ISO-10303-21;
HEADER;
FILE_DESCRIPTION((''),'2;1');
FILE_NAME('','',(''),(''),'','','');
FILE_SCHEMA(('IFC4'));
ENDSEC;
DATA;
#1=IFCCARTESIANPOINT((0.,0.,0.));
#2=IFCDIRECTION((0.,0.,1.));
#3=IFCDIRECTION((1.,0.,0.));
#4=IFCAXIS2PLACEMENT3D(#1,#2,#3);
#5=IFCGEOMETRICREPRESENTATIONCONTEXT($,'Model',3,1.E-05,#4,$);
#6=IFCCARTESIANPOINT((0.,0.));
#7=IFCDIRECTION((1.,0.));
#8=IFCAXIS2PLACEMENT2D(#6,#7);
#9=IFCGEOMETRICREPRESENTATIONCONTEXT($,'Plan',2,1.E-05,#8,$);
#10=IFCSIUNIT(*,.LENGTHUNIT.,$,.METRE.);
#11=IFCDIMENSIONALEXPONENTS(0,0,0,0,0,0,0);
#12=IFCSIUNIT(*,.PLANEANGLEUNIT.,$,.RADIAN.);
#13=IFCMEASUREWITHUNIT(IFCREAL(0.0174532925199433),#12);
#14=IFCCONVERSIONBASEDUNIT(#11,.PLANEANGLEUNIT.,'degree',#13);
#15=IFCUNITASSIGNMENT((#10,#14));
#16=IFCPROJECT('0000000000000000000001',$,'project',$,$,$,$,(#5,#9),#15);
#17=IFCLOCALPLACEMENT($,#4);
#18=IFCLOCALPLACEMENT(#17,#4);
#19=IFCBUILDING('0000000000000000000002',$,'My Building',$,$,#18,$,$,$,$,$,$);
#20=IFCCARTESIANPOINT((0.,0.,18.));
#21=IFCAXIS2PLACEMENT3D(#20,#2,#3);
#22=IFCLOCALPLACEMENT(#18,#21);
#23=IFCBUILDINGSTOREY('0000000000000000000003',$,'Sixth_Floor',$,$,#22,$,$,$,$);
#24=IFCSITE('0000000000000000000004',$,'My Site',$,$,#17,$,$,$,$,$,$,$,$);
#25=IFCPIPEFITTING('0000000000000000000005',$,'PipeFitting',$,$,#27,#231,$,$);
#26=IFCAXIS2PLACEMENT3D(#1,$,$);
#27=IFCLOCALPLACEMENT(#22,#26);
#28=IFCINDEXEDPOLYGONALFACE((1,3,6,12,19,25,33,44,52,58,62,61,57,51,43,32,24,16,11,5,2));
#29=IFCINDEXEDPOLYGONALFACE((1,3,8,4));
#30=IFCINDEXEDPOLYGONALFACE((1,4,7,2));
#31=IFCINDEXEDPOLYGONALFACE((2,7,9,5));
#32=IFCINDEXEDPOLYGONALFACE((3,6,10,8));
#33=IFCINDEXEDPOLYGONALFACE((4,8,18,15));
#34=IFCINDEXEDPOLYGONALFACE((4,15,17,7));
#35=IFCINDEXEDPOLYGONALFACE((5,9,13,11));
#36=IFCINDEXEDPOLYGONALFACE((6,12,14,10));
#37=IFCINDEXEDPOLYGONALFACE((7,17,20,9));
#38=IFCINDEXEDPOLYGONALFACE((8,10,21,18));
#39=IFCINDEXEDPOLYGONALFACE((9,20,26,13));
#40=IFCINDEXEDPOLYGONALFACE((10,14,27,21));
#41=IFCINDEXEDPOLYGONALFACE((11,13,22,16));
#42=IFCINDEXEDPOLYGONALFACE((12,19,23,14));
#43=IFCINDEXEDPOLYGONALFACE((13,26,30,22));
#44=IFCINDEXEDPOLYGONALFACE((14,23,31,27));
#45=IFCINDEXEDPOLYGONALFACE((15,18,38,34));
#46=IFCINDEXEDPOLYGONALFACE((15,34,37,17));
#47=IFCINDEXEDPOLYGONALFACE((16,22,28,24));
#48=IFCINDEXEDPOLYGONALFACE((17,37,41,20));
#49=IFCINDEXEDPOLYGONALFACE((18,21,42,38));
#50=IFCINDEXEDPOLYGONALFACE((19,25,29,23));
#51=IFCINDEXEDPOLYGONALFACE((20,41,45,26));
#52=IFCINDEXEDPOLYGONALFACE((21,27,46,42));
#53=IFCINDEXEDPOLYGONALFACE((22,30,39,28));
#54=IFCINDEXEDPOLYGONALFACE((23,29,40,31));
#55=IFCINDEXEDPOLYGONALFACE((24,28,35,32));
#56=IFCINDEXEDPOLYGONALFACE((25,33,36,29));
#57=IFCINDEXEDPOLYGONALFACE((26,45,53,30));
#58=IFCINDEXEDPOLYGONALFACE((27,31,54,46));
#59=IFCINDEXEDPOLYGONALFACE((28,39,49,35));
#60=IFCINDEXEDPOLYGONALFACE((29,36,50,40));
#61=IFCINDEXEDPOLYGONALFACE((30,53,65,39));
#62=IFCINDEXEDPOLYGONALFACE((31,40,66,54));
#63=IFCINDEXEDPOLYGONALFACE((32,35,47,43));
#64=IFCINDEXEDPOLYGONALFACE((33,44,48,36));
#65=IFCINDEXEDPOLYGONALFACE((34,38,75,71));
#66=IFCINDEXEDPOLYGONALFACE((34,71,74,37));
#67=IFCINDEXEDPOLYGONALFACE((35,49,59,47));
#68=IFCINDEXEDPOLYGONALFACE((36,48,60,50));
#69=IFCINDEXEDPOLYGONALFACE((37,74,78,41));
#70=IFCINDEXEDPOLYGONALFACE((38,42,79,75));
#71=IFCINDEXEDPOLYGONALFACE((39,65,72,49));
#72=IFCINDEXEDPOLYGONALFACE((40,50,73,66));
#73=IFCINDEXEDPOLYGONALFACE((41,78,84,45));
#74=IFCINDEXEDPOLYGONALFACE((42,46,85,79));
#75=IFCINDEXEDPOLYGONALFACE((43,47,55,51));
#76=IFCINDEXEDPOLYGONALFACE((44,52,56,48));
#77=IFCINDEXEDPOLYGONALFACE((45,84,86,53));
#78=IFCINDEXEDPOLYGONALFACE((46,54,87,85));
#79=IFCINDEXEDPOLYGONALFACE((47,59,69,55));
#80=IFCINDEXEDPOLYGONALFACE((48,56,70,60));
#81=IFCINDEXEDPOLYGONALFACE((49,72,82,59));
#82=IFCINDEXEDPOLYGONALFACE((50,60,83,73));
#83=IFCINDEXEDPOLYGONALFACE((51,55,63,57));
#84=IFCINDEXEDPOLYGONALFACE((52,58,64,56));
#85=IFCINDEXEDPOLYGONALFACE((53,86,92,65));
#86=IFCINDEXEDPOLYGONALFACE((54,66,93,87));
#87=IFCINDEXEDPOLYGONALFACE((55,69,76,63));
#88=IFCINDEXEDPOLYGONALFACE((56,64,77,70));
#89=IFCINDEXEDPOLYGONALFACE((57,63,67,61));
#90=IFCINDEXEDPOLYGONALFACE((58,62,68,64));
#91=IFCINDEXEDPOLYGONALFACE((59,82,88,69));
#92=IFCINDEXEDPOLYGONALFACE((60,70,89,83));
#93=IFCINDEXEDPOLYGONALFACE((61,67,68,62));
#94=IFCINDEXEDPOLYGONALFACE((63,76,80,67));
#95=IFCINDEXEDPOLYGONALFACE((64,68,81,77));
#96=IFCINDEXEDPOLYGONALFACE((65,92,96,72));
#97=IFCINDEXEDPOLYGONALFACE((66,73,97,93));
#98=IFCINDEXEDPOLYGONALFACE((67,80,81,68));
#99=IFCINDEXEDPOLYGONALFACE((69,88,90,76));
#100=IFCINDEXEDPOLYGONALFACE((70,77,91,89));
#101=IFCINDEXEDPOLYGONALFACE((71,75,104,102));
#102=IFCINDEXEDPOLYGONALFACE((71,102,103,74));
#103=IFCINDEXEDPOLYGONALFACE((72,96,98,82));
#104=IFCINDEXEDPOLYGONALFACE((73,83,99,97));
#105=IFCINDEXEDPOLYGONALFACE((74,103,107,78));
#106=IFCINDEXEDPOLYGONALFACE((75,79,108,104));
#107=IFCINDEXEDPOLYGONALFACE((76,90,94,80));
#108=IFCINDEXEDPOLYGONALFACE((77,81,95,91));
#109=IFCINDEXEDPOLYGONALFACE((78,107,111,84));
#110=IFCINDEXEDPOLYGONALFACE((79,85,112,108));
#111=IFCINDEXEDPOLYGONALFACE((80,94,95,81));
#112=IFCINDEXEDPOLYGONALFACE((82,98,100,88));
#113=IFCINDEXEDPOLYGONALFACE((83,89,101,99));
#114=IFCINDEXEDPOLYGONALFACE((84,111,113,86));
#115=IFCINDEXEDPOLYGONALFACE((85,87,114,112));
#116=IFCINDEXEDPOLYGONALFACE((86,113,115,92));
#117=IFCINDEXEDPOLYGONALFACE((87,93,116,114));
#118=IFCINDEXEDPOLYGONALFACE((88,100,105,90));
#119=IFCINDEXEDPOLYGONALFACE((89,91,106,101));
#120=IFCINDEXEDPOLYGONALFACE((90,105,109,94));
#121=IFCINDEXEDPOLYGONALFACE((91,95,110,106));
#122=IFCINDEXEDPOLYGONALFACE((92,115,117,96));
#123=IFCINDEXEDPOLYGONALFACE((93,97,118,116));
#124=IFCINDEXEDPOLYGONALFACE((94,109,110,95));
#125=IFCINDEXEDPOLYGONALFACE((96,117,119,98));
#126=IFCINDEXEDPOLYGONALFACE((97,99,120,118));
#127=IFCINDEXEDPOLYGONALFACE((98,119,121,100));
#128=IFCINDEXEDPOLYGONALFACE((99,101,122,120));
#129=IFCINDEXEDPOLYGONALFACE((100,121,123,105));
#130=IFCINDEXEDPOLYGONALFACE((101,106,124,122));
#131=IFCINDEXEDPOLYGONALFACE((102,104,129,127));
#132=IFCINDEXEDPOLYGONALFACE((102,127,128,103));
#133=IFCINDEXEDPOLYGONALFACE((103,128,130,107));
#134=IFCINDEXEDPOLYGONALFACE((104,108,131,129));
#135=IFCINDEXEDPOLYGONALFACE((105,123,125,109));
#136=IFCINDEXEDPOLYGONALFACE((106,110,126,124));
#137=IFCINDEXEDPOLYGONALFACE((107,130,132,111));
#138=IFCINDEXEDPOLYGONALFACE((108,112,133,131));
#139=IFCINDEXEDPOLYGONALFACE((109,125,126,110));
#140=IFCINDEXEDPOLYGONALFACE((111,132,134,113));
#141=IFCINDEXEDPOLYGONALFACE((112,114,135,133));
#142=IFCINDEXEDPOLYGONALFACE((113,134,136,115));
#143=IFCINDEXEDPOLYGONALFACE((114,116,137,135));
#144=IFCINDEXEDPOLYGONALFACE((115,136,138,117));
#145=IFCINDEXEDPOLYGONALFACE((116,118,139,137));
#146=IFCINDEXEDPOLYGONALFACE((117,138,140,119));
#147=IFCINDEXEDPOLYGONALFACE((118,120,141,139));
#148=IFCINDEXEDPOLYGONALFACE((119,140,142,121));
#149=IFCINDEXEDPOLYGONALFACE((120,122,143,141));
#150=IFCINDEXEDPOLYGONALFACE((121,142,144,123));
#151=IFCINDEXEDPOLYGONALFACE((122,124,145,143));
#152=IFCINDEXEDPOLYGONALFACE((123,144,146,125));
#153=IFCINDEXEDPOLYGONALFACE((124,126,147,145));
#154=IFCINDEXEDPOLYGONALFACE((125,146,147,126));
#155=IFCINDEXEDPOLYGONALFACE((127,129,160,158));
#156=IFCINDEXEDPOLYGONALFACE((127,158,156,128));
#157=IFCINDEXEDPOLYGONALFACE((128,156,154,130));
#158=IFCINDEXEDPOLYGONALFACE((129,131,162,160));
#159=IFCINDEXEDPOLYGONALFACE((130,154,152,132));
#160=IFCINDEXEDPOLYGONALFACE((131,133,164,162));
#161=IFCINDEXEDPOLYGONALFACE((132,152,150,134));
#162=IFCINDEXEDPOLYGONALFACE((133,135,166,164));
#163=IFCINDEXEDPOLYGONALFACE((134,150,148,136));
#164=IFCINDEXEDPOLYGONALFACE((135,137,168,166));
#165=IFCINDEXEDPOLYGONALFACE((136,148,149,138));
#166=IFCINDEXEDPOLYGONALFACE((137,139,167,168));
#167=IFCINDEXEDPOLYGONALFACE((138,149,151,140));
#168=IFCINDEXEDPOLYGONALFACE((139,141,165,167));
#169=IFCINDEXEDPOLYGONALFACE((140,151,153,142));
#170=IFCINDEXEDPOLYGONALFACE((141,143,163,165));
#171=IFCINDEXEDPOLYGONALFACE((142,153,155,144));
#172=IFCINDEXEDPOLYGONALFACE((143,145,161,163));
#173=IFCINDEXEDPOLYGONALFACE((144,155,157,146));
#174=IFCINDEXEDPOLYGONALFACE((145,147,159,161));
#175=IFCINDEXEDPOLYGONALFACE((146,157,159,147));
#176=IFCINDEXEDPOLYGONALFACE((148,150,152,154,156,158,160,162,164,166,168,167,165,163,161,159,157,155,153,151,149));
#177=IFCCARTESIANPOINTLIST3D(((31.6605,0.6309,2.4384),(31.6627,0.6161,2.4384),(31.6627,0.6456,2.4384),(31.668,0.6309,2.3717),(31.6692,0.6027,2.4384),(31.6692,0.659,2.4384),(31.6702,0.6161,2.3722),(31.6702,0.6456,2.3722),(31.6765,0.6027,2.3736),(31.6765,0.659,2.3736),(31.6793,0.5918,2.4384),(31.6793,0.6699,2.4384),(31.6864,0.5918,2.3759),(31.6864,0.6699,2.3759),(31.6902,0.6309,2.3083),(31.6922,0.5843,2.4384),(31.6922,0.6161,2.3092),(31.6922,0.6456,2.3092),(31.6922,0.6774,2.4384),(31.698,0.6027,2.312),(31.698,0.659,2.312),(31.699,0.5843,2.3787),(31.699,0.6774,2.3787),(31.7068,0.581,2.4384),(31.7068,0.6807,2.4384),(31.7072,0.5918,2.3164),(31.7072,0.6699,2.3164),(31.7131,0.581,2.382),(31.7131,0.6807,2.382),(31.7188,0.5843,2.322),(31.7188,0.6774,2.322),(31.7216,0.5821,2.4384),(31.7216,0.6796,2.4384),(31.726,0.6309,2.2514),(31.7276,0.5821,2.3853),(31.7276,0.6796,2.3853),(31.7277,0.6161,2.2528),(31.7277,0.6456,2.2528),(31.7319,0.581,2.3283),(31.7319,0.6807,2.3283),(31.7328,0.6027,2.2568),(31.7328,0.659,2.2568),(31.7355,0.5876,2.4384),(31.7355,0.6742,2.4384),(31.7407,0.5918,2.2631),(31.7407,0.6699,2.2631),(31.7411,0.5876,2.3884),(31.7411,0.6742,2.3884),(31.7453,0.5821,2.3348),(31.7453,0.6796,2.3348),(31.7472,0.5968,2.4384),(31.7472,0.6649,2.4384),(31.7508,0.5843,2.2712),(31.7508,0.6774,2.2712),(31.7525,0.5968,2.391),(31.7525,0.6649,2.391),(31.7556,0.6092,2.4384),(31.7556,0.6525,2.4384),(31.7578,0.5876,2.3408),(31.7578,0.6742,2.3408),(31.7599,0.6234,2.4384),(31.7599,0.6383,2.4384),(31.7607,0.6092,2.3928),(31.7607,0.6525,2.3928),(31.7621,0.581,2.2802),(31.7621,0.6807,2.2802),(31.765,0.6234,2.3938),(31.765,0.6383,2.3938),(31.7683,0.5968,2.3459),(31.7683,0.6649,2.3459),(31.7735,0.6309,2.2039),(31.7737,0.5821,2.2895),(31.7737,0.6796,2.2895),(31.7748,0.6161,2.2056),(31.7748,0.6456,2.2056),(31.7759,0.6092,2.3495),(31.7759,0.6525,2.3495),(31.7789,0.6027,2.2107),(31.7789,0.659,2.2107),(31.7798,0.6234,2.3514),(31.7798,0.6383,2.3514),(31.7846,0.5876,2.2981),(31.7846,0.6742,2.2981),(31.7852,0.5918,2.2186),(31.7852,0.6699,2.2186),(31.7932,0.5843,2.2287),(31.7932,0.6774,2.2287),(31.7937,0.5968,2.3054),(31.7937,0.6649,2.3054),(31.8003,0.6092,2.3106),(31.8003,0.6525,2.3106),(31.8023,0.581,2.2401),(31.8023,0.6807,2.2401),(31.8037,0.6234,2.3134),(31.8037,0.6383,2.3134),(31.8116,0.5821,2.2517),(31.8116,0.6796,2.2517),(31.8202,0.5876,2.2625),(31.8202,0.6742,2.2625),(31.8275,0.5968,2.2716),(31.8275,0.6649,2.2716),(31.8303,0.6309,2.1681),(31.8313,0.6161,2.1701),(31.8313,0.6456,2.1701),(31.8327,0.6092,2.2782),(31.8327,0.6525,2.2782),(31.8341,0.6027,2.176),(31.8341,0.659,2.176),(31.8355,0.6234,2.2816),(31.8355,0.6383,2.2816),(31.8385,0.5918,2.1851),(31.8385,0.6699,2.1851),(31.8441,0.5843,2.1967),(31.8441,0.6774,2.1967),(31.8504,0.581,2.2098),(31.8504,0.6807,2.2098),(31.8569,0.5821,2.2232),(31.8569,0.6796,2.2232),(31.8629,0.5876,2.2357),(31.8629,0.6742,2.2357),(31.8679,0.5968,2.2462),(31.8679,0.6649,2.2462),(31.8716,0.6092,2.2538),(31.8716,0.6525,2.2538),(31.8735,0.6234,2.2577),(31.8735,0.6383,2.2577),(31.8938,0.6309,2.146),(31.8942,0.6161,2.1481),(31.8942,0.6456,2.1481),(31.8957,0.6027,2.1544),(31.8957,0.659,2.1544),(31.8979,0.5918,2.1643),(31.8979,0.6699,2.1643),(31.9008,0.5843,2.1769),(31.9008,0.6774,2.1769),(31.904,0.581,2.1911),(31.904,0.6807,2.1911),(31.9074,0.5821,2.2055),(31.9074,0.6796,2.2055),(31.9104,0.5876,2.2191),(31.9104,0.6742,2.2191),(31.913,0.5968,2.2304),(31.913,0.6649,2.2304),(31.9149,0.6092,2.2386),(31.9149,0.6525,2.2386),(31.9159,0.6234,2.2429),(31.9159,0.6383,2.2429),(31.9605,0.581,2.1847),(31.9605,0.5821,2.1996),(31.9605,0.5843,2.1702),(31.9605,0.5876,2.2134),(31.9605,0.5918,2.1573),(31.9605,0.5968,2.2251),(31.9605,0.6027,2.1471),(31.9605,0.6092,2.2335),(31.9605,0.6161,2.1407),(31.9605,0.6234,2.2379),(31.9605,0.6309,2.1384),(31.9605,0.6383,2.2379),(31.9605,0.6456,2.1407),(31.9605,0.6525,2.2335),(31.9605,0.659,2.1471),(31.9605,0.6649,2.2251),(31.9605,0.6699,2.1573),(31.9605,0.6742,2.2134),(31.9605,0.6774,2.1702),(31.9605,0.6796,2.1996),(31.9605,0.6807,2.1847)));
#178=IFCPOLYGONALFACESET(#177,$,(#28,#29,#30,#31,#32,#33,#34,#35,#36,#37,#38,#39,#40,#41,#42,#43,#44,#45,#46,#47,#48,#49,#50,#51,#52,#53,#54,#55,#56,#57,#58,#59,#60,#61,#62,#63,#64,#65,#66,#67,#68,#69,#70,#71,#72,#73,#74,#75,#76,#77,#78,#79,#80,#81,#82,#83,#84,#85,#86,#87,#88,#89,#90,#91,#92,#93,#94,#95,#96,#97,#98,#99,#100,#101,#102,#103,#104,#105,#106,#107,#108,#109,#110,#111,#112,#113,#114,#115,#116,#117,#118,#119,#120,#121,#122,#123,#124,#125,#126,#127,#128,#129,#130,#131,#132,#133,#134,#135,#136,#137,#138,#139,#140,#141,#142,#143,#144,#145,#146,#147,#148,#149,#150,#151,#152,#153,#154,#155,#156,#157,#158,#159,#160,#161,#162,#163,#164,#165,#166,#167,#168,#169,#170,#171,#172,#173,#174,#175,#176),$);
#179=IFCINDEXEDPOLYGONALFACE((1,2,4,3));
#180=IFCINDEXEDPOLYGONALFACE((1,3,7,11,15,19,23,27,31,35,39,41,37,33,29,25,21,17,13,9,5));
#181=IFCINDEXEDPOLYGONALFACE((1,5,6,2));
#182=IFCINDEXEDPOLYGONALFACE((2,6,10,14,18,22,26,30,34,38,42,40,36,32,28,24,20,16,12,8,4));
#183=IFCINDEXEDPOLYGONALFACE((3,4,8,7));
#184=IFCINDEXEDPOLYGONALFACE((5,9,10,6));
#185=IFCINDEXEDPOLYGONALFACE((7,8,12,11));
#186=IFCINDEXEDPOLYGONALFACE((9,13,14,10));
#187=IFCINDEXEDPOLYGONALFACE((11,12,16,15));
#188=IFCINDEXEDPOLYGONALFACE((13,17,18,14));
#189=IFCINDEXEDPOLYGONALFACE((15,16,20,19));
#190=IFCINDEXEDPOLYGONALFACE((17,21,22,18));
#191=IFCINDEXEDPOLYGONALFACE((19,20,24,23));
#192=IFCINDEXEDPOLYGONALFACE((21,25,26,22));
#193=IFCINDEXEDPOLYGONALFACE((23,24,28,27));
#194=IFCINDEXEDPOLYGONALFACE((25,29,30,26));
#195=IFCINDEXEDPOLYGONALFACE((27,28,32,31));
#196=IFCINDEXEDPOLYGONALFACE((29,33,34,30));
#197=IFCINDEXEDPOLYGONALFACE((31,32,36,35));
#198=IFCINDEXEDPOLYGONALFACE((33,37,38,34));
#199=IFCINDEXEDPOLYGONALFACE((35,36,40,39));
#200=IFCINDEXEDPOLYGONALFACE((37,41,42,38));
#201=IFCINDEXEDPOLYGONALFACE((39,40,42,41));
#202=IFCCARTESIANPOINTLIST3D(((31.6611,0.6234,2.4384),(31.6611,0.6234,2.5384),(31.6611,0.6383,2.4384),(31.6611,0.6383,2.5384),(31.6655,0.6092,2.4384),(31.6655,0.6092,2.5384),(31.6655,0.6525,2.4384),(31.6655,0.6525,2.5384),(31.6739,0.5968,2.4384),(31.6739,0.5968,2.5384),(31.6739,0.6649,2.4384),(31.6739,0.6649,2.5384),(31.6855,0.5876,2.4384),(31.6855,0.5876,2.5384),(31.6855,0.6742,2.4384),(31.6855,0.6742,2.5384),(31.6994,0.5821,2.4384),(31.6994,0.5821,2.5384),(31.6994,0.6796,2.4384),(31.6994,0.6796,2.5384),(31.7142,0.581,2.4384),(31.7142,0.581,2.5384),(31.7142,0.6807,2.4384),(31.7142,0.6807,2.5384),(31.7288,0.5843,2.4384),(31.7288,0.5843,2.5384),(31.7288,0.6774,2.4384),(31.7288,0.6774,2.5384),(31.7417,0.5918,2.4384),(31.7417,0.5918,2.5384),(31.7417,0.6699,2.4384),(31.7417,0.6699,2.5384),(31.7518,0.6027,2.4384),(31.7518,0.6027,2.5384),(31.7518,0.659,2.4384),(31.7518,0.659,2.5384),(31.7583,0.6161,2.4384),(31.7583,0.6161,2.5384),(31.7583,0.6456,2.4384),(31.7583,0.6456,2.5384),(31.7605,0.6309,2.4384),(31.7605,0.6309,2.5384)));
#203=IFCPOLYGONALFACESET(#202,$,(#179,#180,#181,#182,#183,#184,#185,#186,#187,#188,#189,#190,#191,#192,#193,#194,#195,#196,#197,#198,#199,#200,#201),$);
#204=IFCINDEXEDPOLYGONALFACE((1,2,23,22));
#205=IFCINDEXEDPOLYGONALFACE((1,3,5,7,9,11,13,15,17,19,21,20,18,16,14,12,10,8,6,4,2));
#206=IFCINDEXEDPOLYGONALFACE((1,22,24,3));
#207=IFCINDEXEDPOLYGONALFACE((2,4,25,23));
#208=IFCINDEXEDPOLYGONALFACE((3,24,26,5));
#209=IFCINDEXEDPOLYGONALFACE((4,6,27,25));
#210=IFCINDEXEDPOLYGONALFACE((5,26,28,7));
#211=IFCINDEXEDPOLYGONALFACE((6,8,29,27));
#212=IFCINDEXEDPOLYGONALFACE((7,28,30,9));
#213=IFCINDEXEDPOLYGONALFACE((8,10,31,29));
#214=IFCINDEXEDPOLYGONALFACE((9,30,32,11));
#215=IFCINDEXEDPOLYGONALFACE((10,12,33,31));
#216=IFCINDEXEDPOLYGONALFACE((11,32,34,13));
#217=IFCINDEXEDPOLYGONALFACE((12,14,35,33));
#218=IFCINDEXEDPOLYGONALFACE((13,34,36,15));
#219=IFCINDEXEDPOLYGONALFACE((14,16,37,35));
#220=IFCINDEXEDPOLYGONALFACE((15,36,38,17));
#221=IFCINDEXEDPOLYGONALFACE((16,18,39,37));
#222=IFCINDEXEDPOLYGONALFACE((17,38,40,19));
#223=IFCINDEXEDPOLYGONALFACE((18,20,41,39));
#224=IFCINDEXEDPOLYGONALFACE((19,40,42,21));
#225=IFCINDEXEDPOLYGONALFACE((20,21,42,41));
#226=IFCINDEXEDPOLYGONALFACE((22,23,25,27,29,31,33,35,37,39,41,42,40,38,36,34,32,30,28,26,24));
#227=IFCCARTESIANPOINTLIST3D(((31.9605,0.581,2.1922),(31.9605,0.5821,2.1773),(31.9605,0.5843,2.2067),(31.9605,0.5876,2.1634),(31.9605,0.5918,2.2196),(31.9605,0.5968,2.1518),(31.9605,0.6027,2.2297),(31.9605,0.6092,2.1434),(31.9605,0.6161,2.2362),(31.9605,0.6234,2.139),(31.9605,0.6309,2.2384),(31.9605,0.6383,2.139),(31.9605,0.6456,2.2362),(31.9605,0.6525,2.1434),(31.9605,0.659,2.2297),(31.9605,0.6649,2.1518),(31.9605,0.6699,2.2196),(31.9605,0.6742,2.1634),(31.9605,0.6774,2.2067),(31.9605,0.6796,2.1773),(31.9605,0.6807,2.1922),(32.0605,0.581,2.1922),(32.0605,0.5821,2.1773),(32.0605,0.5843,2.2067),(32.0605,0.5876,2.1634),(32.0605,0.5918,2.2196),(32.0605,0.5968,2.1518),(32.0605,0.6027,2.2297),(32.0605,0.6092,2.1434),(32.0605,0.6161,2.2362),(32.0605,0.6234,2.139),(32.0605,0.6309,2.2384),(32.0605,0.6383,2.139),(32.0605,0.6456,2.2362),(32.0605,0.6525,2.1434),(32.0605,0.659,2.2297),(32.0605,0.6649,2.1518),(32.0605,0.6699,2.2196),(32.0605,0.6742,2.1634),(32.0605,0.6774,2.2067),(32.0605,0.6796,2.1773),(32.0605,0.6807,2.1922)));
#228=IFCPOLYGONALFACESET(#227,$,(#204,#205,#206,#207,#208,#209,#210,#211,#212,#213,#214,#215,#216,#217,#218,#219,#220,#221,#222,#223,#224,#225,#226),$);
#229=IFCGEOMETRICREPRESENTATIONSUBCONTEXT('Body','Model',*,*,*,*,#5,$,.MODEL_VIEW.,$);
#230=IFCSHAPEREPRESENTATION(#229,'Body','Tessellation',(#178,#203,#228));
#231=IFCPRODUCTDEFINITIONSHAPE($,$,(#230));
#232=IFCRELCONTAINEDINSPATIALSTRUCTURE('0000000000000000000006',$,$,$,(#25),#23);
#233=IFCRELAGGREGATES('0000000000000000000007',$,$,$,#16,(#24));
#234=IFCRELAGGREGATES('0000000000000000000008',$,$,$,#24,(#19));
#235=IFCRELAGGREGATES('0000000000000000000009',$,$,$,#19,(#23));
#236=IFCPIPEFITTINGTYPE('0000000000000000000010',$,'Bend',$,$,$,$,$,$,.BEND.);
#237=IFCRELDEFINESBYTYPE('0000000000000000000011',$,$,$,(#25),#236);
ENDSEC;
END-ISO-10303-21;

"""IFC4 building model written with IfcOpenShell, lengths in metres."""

from ifc_helpers import new_model, entity, si_unit, converted_unit, frame, origin_with_axes, origin_2d_with_axis, place, context, subcontext, project, spatial, circle, extrude, source, transform, mapped, type_object, type_shapes, element, save


model = new_model("IFC4")

# Units and contexts
model_context = context("Model", 3, precision=1e-05, world=origin_with_axes())
plan_context = context("Plan", 2, precision=1e-05, world=origin_2d_with_axis())
body_context = subcontext(model_context, "Body", "Model", "MODEL_VIEW")
ifc_project = project(units=[si_unit("LENGTHUNIT", "METRE"), converted_unit("PLANEANGLEUNIT", "degree", entity("IfcReal", 0.0174532925199433), si_unit("PLANEANGLEUNIT", "RADIAN"), dimensions=[0, 0, 0, 0, 0, 0, 0])], contexts=[model_context, plan_context])

# Site, building, storey
site_placement = place(None, origin_with_axes())
site = spatial("IfcSite", under=ifc_project, at=site_placement, Name="My Site")
building_placement = place(site_placement, origin_with_axes())
building = spatial("IfcBuilding", under=site, at=building_placement, Name="My Building")
storey_placement = place(building_placement, frame((0.0, 0.0, 18.0), z_axis=(0.0, 0.0, 1.0), x_axis=(1.0, 0.0, 0.0)))
storey = spatial("IfcBuildingStorey", under=building, at=storey_placement, Name="Sixth_Floor")

# Pipe fitting
pipe_fitting_type = type_object("IfcPipeFittingType", Name="Bend", PredefinedType="BEND")
shared_shape = source(origin_with_axes(), body_context, "Body", "SolidModel", [
    entity("IfcSweptDiskSolid", entity("IfcIndexedPolyCurve", entity("IfcCartesianPointList3D", [[0.0, 0.0, -0.1], [0.0732, 0.0, -0.2768], [0.25, 0.0, -0.35]]), [entity("IfcArcIndex", [1, 2, 3])]), 0.05),
    extrude(circle(Radius=0.05), origin_with_axes(), (0.0, 0.0, -1.0), 0.1),
    extrude(circle(Radius=0.05), frame((0.25, 0.0, -0.35), z_axis=(1.0, 0.0, 0.0), x_axis=(0.0, 0.0, 1.0)), (0.0, 0.0, 1.0), 0.1),
])
type_shapes(pipe_fitting_type, [shared_shape])
for number, where, z_axis, x_axis, name in (
    (1, (31.7105, 0.6309, 2.5384), (0.0, 0.0, 1.0), (1.0, 0.0, 0.0), "PipeFitting"),
):
    element("IfcPipeFitting", number, at=place(storey_placement, frame(where, z_axis=z_axis, x_axis=x_axis)), inside=storey, type_object=pipe_fitting_type, Name=name, context=body_context, shape_type="MappedRepresentation", body=[
        mapped(shared_shape, transform((0.0, 0.0, 0.0), x_axis=(1.0, 0.0, 0.0), y_axis=(0.0, 1.0, 0.0), z_axis=(0.0, 0.0, 1.0), scale=1.0)),
    ])

save(model, "model.ifc")
